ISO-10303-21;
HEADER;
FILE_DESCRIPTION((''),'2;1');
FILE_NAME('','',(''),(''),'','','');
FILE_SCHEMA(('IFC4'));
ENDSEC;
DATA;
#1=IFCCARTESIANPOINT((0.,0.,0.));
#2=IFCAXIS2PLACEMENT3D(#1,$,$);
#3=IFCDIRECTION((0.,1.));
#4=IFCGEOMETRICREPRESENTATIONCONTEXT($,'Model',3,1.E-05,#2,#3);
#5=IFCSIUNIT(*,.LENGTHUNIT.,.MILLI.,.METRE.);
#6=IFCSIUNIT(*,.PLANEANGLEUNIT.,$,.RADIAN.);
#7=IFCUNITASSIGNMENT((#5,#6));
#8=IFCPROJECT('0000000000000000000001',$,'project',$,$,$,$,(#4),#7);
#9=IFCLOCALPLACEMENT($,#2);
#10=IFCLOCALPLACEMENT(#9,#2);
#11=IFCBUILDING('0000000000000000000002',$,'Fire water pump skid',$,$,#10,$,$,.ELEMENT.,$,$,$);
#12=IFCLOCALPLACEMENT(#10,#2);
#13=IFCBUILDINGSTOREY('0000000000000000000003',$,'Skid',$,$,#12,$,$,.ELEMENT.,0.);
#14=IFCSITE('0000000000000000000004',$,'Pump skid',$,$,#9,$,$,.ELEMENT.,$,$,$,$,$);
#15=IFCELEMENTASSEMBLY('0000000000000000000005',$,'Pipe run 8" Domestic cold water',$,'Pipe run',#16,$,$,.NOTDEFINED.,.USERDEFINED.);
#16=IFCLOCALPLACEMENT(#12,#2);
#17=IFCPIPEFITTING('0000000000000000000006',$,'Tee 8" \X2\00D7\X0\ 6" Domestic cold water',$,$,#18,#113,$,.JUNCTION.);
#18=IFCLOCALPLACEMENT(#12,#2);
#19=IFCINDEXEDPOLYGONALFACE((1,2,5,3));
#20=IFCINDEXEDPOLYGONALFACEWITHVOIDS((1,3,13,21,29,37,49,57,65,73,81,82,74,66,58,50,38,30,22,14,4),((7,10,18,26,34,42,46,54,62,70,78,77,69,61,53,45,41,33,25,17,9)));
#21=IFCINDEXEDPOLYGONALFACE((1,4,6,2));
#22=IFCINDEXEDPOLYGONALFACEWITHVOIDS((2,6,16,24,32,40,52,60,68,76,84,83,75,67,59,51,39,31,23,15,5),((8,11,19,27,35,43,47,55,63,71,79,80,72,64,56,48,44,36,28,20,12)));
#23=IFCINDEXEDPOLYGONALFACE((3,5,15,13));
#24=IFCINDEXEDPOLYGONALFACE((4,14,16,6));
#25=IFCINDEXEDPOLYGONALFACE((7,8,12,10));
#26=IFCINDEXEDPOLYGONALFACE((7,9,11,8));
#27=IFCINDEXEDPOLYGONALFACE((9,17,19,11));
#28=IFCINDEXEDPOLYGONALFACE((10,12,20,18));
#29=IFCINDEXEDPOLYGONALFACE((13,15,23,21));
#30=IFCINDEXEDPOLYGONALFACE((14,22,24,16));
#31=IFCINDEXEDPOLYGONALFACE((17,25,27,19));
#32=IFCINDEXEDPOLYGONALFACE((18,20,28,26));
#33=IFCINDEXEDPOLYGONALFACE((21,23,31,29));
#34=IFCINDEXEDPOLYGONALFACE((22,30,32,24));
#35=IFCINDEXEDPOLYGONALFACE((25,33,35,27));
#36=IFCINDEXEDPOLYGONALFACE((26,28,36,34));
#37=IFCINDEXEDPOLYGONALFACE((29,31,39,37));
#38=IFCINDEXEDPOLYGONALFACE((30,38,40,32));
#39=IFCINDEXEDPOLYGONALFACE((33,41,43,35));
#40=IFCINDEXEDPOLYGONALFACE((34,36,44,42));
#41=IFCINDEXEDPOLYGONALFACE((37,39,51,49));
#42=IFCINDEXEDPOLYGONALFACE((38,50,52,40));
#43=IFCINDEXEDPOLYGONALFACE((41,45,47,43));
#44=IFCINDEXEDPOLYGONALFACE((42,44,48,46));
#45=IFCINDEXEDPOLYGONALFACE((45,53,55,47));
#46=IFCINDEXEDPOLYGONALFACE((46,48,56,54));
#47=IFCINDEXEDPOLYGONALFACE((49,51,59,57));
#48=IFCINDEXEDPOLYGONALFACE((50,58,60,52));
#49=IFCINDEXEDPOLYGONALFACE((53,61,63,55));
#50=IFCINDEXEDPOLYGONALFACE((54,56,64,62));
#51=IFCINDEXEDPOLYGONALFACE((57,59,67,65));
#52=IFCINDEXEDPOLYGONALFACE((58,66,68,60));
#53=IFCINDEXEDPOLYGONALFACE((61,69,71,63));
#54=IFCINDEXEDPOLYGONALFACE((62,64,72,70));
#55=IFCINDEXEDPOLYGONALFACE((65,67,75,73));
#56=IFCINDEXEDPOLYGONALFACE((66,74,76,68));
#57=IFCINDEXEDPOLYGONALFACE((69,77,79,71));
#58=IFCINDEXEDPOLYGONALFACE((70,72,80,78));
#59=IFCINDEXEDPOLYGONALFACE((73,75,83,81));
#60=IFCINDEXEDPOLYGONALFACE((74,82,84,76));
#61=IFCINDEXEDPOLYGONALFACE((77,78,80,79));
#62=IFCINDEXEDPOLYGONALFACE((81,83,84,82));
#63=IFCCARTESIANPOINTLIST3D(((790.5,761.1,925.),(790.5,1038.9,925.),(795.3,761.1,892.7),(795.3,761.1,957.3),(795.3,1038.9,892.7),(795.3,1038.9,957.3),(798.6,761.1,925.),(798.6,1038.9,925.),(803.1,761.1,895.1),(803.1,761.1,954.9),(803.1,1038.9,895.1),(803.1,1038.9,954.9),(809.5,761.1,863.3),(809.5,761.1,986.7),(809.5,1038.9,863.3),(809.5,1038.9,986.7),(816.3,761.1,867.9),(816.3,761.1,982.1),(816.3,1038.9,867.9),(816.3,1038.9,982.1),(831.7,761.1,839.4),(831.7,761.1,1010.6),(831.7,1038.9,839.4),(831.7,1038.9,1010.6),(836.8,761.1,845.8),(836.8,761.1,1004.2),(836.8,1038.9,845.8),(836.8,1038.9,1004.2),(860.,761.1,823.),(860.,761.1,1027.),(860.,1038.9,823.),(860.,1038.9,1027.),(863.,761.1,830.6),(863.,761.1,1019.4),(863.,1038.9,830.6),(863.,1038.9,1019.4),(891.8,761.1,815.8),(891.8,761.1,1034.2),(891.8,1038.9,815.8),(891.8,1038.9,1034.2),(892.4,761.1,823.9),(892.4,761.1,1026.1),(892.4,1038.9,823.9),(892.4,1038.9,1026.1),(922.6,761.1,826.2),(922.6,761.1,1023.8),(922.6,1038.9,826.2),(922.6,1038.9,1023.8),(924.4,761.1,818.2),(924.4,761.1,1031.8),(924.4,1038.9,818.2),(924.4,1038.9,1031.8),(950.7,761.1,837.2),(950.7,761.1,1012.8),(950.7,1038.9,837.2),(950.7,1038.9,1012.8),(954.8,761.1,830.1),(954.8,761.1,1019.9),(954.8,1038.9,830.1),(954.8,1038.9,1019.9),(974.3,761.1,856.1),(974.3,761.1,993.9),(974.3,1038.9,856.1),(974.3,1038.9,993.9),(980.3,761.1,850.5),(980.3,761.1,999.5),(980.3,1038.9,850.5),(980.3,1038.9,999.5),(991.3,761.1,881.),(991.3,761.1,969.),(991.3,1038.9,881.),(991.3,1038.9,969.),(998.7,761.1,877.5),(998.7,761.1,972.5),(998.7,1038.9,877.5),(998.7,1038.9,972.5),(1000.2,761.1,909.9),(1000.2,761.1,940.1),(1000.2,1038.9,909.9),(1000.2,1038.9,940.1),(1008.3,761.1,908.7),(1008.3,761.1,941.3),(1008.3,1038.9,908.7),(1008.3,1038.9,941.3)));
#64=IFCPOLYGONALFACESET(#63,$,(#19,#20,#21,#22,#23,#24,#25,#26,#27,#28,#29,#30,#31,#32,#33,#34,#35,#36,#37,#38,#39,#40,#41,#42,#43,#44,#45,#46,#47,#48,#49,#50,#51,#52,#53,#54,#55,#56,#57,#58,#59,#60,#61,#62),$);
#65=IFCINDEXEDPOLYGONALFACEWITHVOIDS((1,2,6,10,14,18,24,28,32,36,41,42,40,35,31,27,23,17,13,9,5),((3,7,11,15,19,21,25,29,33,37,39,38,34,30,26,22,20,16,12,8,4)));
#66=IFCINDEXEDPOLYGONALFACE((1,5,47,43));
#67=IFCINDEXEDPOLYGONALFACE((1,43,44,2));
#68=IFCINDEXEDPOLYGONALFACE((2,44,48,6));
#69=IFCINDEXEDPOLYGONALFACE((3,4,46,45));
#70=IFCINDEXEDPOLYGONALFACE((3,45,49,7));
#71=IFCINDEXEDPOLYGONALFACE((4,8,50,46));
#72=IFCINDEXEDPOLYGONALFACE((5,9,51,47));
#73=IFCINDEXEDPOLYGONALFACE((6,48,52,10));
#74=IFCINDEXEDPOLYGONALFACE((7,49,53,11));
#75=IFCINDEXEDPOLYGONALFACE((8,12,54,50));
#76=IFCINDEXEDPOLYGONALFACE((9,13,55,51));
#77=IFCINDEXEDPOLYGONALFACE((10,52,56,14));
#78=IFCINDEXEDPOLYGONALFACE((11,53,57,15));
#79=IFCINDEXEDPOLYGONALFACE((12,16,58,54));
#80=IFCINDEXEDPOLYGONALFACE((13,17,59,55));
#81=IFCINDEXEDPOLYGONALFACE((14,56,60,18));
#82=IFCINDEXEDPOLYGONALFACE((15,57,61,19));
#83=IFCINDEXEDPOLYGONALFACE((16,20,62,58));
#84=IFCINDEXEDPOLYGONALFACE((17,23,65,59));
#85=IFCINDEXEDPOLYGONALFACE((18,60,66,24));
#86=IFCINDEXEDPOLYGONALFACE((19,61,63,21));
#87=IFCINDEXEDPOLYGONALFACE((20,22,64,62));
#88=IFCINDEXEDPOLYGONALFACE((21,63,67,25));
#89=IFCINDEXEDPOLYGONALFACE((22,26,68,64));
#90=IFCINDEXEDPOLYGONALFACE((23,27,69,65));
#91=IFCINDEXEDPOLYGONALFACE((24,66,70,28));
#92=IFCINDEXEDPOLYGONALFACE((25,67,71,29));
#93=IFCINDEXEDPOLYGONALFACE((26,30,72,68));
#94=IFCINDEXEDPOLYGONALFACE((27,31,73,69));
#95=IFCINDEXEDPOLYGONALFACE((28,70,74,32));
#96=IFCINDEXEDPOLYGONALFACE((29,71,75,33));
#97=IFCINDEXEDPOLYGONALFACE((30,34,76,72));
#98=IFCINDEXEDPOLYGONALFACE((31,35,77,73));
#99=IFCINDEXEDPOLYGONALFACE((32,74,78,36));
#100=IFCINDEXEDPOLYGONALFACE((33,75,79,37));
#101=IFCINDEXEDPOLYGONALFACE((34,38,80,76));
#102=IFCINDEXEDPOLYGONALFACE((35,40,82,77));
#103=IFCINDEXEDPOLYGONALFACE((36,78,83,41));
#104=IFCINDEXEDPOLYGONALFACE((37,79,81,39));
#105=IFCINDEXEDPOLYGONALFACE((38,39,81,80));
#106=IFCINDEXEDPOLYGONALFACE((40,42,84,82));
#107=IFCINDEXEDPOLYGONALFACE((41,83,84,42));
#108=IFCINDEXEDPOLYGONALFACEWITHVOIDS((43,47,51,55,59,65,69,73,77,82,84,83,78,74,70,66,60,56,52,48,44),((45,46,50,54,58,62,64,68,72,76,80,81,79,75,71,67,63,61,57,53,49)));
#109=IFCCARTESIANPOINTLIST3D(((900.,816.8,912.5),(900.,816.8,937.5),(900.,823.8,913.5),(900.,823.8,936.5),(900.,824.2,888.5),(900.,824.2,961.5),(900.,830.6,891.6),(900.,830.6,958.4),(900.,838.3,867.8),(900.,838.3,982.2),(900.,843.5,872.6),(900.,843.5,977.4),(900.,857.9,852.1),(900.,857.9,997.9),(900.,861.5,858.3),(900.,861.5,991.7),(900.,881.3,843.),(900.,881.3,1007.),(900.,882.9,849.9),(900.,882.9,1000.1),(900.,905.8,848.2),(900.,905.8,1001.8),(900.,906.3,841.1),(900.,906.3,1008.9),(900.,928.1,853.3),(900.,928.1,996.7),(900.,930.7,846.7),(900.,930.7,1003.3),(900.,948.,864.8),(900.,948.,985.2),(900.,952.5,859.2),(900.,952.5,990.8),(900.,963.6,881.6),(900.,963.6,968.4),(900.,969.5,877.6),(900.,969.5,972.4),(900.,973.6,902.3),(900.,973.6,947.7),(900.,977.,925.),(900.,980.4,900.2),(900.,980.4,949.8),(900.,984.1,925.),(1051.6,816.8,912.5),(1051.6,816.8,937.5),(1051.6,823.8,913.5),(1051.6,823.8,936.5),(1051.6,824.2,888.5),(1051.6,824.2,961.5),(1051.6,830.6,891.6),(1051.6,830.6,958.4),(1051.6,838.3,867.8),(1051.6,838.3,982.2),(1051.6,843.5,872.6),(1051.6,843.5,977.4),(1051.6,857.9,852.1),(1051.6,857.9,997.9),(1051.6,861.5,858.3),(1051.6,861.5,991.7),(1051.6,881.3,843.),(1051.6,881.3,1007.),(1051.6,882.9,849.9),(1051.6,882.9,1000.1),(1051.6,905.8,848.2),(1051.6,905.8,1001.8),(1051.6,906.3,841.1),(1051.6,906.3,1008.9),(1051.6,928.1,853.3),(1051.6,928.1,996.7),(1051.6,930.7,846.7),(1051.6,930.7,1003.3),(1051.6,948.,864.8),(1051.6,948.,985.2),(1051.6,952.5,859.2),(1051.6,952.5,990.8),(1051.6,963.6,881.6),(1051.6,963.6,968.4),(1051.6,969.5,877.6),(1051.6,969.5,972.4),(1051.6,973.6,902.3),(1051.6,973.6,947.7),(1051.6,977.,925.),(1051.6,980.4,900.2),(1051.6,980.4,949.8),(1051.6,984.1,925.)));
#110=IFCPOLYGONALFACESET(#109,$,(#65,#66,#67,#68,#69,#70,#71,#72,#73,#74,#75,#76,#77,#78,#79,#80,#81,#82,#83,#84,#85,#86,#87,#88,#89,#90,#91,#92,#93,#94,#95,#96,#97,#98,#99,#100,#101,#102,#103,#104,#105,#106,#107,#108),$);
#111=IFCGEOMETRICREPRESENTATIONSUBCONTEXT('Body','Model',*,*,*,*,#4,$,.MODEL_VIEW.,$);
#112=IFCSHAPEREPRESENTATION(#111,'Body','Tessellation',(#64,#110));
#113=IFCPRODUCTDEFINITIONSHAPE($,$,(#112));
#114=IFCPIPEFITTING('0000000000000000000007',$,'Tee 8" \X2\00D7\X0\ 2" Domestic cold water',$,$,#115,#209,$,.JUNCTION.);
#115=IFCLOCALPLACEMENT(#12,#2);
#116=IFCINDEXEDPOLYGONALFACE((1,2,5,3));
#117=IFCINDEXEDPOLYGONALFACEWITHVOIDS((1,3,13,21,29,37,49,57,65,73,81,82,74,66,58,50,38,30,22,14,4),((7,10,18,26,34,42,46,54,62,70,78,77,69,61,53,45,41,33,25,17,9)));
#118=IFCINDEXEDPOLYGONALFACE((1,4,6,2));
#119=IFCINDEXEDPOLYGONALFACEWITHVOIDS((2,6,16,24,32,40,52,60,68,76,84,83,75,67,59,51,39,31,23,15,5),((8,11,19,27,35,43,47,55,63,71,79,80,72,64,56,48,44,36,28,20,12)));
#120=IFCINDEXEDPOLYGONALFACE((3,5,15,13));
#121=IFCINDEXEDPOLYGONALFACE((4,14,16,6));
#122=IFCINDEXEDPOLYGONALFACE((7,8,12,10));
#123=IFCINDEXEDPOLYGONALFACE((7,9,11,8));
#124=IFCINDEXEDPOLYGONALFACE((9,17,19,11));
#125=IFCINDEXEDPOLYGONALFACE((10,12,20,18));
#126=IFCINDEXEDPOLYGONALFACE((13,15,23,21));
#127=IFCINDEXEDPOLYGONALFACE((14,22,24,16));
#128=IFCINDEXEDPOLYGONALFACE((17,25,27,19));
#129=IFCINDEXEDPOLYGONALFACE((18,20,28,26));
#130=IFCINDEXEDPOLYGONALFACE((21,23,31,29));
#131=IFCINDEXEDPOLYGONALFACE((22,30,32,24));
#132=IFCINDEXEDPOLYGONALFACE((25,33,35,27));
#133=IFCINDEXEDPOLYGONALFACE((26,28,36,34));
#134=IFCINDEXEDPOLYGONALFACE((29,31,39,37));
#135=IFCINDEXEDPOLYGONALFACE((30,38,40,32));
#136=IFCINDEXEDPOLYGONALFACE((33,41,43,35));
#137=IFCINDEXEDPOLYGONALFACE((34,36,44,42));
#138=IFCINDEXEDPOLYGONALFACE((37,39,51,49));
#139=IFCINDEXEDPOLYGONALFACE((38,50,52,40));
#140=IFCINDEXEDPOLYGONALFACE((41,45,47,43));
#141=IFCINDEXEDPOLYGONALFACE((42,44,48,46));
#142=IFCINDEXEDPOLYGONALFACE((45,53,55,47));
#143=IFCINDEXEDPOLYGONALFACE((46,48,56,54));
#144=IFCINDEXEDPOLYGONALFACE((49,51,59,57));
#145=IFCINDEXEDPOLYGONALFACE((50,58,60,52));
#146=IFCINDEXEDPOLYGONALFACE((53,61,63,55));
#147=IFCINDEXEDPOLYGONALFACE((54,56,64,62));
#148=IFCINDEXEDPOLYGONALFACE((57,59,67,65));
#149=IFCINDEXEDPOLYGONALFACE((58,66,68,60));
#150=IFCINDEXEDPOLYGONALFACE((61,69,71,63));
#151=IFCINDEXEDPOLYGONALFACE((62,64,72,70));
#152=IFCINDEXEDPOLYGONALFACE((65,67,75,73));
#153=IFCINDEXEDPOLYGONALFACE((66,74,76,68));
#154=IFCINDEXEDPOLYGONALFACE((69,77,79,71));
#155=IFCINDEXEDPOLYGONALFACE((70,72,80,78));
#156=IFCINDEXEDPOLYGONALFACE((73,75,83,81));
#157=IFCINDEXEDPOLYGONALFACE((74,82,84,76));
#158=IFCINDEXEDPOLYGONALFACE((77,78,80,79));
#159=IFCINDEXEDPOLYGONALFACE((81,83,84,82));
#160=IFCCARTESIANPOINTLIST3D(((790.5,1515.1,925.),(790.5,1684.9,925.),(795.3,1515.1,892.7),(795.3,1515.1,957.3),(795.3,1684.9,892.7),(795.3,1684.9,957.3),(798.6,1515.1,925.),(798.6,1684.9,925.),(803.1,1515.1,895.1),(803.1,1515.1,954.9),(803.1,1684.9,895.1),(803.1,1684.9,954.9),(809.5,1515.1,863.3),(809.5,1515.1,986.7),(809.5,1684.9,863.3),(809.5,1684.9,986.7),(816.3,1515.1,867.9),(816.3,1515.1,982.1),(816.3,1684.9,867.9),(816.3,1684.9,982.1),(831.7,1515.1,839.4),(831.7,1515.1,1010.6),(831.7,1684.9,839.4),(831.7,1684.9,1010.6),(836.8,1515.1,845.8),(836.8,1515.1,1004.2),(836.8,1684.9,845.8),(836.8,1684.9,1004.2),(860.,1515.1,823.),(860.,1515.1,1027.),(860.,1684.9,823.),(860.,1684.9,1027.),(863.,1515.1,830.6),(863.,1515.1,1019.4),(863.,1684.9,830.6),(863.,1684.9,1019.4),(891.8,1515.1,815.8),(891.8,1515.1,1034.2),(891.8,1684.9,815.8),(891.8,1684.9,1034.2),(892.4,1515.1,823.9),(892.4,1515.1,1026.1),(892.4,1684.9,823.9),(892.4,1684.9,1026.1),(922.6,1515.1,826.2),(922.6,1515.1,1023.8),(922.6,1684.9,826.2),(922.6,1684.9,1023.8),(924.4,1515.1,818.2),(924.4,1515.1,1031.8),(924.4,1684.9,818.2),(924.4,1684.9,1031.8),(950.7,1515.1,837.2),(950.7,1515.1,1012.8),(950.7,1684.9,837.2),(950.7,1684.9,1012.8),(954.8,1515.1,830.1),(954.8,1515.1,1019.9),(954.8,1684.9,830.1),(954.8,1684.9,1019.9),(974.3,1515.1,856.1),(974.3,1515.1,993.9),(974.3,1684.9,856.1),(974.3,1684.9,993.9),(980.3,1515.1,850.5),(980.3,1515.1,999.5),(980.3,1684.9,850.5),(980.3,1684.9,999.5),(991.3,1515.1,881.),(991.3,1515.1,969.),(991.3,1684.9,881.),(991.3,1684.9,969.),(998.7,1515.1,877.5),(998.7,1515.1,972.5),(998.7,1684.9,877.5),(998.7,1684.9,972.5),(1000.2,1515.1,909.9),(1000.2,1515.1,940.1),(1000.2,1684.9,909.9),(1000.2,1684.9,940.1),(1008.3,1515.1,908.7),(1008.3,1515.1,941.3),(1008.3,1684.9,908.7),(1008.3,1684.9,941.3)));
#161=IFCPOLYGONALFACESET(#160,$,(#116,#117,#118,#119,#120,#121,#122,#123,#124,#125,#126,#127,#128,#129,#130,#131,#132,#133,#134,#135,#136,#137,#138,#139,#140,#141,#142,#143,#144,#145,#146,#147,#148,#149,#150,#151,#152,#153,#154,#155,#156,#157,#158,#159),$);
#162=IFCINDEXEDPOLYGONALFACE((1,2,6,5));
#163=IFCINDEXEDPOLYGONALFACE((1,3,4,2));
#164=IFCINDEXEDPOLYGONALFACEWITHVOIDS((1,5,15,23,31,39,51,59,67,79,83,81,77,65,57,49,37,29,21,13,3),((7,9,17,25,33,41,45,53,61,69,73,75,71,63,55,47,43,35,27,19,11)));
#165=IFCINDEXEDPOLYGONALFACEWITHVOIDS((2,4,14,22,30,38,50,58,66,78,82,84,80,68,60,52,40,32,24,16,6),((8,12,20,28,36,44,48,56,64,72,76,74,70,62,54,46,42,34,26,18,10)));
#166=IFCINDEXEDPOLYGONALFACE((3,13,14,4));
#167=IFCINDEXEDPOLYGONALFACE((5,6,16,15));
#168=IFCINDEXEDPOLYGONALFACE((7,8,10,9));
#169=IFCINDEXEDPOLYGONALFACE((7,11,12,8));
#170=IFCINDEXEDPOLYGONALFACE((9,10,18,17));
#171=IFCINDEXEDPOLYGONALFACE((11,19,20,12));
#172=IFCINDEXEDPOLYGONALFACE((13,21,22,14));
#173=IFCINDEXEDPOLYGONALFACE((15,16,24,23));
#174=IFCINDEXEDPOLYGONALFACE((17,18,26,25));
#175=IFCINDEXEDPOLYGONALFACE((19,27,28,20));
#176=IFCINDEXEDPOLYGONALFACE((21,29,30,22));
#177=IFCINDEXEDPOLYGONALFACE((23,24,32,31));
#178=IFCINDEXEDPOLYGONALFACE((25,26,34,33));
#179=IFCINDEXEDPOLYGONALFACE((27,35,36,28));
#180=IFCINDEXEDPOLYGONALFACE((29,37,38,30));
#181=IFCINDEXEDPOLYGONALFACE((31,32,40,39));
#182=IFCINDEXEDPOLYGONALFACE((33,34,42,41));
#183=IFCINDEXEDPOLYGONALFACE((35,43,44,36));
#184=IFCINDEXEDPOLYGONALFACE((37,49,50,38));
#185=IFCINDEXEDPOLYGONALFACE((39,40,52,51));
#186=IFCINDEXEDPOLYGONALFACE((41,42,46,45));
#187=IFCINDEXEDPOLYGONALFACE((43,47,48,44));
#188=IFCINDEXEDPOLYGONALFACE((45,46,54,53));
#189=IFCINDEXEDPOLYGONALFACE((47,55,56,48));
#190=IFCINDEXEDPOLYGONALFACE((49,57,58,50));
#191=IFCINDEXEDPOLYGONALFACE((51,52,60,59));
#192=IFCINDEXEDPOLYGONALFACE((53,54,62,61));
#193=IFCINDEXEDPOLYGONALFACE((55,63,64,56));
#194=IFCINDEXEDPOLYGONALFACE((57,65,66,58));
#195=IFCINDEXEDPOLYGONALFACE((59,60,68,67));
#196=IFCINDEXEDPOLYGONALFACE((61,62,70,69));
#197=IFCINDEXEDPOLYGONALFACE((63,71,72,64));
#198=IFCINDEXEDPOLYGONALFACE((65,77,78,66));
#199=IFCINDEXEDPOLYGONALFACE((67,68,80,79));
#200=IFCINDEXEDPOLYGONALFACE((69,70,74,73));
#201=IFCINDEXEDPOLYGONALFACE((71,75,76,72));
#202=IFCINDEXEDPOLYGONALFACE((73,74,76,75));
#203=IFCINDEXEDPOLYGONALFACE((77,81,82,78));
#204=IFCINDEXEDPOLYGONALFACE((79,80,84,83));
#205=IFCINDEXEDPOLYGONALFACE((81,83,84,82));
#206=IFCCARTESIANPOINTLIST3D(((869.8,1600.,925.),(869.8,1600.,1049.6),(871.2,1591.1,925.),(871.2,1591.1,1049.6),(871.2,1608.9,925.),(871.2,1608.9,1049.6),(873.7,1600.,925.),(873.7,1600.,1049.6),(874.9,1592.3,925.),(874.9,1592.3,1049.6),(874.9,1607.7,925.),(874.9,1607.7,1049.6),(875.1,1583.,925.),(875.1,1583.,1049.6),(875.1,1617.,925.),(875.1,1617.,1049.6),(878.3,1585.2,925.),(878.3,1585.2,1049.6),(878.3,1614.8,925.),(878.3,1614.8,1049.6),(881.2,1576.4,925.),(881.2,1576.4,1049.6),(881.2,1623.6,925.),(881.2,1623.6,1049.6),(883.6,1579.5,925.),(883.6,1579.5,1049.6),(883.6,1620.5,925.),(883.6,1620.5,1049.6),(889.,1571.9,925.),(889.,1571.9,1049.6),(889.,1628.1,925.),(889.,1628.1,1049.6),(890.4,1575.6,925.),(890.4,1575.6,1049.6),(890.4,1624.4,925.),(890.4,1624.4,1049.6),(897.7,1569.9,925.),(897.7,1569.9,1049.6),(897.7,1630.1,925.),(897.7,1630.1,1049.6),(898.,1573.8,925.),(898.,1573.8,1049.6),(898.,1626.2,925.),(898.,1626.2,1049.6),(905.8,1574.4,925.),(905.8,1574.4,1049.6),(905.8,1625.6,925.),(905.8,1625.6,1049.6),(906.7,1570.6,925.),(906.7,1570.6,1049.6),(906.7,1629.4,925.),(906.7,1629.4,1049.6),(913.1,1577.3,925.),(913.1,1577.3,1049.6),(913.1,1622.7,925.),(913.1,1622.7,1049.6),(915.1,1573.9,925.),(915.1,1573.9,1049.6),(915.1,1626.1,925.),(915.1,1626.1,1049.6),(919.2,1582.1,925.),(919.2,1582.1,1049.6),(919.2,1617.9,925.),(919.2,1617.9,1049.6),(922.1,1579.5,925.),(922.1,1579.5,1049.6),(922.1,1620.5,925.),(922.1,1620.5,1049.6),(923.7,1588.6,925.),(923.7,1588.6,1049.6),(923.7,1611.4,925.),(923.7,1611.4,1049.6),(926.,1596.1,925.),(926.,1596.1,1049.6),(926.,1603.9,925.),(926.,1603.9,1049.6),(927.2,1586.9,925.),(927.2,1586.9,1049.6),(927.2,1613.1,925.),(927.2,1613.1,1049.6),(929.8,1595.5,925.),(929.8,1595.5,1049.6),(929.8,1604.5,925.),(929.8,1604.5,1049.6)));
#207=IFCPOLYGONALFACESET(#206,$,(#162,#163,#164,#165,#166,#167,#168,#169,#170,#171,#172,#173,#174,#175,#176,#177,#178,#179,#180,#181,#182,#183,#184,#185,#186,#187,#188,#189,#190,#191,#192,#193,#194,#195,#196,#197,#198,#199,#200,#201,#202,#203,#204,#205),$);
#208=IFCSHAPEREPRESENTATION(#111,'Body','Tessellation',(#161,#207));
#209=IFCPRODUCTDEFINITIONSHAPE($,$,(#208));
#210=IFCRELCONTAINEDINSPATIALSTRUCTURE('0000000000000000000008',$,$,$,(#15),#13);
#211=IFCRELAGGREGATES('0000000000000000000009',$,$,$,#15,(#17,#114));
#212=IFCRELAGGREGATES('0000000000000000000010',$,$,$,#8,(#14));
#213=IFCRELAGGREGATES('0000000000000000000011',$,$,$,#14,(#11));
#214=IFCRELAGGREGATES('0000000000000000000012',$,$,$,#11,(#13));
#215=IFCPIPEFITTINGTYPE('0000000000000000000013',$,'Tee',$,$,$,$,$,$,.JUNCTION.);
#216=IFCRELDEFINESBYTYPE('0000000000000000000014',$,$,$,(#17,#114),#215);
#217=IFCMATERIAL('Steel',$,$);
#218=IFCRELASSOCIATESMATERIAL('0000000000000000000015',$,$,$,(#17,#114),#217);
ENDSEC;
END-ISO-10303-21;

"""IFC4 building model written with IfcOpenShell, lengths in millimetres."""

from ifc_helpers import new_model, si_unit, direction, frame, origin, origin_with_axes, origin_2d, place, context, subcontext, project, spatial, hollow_circle, extrude, material, type_object, element, aggregate, save


model = new_model("IFC4")

# Units and contexts
model_context = context("Model", 3, precision=1e-05, world=origin(), true_north=direction((0.0, 1.0)))
body_context = subcontext(model_context, "Body", "Model", "MODEL_VIEW")
ifc_project = project(units=[si_unit("LENGTHUNIT", "METRE", prefix="MILLI"), si_unit("PLANEANGLEUNIT", "RADIAN")], contexts=[model_context])

# Site, building, storey
site_placement = place(None, origin())
site = spatial("IfcSite", under=ifc_project, at=site_placement, Name="Pump skid", CompositionType="ELEMENT")
building_placement = place(site_placement, origin())
building = spatial("IfcBuilding", under=site, at=building_placement, Name="Fire water pump skid", CompositionType="ELEMENT")
storey_placement = place(building_placement, origin())
storey = spatial("IfcBuildingStorey", under=building, at=storey_placement, Name="Skid", CompositionType="ELEMENT", Elevation=0.0)

# Element assembly
ifc_material = material(Name="Steel")
assembly_1_placement = place(storey_placement, origin_with_axes())
assembly_1 = element("IfcElementAssembly", 1, at=assembly_1_placement, inside=storey, Name="Pipe run 8\" Domestic cold water", ObjectType="Pipe run", AssemblyPlace="NOTDEFINED", PredefinedType="USERDEFINED")

# Pipe fittings
pipe_fitting_type_1 = type_object("IfcPipeFittingType", Name="Tee", PredefinedType="JUNCTION")
pipe_fitting_1_placement = place(storey_placement, origin_with_axes())
pipe_fitting_1 = element("IfcPipeFitting", 2, at=pipe_fitting_1_placement, type_object=pipe_fitting_type_1, material=ifc_material, Name="Tee 8\" × 6\" Domestic cold water", PredefinedType="JUNCTION", context=body_context, shape_type="SweptSolid", body=[
    extrude(hollow_circle(Radius=109.5, WallThickness=8.2, at=origin_2d()), frame((900.0, 761.1, 925.0), z_axis=(0.0, 1.0, 0.0), x_axis=(-1.0, 0.0, 0.0)), (0.0, 0.0, 1.0), 277.8),
    extrude(hollow_circle(Radius=84.1, WallThickness=7.1, at=origin_2d()), frame((900.0, 900.0, 925.0), z_axis=(1.0, 0.0, 0.0), x_axis=(0.0, 1.0, 0.0)), (0.0, 0.0, 1.0), 151.6),
])
pipe_fitting_2_placement = place(storey_placement, origin_with_axes())
pipe_fitting_2 = element("IfcPipeFitting", 3, at=pipe_fitting_2_placement, type_object=pipe_fitting_type_1, material=ifc_material, Name="Tee 8\" × 2\" Domestic cold water", PredefinedType="JUNCTION", context=body_context, shape_type="SweptSolid", body=[
    extrude(hollow_circle(Radius=109.5, WallThickness=8.2, at=origin_2d()), frame((900.0, 1515.1, 925.0), z_axis=(0.0, 1.0, 0.0), x_axis=(-1.0, 0.0, 0.0)), (0.0, 0.0, 1.0), 169.9),
    extrude(hollow_circle(Radius=30.2, WallThickness=3.9, at=origin_2d()), frame((900.0, 1600.0, 925.0), z_axis=(0.0, 0.0, 1.0), x_axis=(-1.0, 0.0, 0.0)), (0.0, 0.0, 1.0), 124.6),
])
aggregate(assembly_1, [pipe_fitting_1, pipe_fitting_2])

save(model, "model.ifc")
